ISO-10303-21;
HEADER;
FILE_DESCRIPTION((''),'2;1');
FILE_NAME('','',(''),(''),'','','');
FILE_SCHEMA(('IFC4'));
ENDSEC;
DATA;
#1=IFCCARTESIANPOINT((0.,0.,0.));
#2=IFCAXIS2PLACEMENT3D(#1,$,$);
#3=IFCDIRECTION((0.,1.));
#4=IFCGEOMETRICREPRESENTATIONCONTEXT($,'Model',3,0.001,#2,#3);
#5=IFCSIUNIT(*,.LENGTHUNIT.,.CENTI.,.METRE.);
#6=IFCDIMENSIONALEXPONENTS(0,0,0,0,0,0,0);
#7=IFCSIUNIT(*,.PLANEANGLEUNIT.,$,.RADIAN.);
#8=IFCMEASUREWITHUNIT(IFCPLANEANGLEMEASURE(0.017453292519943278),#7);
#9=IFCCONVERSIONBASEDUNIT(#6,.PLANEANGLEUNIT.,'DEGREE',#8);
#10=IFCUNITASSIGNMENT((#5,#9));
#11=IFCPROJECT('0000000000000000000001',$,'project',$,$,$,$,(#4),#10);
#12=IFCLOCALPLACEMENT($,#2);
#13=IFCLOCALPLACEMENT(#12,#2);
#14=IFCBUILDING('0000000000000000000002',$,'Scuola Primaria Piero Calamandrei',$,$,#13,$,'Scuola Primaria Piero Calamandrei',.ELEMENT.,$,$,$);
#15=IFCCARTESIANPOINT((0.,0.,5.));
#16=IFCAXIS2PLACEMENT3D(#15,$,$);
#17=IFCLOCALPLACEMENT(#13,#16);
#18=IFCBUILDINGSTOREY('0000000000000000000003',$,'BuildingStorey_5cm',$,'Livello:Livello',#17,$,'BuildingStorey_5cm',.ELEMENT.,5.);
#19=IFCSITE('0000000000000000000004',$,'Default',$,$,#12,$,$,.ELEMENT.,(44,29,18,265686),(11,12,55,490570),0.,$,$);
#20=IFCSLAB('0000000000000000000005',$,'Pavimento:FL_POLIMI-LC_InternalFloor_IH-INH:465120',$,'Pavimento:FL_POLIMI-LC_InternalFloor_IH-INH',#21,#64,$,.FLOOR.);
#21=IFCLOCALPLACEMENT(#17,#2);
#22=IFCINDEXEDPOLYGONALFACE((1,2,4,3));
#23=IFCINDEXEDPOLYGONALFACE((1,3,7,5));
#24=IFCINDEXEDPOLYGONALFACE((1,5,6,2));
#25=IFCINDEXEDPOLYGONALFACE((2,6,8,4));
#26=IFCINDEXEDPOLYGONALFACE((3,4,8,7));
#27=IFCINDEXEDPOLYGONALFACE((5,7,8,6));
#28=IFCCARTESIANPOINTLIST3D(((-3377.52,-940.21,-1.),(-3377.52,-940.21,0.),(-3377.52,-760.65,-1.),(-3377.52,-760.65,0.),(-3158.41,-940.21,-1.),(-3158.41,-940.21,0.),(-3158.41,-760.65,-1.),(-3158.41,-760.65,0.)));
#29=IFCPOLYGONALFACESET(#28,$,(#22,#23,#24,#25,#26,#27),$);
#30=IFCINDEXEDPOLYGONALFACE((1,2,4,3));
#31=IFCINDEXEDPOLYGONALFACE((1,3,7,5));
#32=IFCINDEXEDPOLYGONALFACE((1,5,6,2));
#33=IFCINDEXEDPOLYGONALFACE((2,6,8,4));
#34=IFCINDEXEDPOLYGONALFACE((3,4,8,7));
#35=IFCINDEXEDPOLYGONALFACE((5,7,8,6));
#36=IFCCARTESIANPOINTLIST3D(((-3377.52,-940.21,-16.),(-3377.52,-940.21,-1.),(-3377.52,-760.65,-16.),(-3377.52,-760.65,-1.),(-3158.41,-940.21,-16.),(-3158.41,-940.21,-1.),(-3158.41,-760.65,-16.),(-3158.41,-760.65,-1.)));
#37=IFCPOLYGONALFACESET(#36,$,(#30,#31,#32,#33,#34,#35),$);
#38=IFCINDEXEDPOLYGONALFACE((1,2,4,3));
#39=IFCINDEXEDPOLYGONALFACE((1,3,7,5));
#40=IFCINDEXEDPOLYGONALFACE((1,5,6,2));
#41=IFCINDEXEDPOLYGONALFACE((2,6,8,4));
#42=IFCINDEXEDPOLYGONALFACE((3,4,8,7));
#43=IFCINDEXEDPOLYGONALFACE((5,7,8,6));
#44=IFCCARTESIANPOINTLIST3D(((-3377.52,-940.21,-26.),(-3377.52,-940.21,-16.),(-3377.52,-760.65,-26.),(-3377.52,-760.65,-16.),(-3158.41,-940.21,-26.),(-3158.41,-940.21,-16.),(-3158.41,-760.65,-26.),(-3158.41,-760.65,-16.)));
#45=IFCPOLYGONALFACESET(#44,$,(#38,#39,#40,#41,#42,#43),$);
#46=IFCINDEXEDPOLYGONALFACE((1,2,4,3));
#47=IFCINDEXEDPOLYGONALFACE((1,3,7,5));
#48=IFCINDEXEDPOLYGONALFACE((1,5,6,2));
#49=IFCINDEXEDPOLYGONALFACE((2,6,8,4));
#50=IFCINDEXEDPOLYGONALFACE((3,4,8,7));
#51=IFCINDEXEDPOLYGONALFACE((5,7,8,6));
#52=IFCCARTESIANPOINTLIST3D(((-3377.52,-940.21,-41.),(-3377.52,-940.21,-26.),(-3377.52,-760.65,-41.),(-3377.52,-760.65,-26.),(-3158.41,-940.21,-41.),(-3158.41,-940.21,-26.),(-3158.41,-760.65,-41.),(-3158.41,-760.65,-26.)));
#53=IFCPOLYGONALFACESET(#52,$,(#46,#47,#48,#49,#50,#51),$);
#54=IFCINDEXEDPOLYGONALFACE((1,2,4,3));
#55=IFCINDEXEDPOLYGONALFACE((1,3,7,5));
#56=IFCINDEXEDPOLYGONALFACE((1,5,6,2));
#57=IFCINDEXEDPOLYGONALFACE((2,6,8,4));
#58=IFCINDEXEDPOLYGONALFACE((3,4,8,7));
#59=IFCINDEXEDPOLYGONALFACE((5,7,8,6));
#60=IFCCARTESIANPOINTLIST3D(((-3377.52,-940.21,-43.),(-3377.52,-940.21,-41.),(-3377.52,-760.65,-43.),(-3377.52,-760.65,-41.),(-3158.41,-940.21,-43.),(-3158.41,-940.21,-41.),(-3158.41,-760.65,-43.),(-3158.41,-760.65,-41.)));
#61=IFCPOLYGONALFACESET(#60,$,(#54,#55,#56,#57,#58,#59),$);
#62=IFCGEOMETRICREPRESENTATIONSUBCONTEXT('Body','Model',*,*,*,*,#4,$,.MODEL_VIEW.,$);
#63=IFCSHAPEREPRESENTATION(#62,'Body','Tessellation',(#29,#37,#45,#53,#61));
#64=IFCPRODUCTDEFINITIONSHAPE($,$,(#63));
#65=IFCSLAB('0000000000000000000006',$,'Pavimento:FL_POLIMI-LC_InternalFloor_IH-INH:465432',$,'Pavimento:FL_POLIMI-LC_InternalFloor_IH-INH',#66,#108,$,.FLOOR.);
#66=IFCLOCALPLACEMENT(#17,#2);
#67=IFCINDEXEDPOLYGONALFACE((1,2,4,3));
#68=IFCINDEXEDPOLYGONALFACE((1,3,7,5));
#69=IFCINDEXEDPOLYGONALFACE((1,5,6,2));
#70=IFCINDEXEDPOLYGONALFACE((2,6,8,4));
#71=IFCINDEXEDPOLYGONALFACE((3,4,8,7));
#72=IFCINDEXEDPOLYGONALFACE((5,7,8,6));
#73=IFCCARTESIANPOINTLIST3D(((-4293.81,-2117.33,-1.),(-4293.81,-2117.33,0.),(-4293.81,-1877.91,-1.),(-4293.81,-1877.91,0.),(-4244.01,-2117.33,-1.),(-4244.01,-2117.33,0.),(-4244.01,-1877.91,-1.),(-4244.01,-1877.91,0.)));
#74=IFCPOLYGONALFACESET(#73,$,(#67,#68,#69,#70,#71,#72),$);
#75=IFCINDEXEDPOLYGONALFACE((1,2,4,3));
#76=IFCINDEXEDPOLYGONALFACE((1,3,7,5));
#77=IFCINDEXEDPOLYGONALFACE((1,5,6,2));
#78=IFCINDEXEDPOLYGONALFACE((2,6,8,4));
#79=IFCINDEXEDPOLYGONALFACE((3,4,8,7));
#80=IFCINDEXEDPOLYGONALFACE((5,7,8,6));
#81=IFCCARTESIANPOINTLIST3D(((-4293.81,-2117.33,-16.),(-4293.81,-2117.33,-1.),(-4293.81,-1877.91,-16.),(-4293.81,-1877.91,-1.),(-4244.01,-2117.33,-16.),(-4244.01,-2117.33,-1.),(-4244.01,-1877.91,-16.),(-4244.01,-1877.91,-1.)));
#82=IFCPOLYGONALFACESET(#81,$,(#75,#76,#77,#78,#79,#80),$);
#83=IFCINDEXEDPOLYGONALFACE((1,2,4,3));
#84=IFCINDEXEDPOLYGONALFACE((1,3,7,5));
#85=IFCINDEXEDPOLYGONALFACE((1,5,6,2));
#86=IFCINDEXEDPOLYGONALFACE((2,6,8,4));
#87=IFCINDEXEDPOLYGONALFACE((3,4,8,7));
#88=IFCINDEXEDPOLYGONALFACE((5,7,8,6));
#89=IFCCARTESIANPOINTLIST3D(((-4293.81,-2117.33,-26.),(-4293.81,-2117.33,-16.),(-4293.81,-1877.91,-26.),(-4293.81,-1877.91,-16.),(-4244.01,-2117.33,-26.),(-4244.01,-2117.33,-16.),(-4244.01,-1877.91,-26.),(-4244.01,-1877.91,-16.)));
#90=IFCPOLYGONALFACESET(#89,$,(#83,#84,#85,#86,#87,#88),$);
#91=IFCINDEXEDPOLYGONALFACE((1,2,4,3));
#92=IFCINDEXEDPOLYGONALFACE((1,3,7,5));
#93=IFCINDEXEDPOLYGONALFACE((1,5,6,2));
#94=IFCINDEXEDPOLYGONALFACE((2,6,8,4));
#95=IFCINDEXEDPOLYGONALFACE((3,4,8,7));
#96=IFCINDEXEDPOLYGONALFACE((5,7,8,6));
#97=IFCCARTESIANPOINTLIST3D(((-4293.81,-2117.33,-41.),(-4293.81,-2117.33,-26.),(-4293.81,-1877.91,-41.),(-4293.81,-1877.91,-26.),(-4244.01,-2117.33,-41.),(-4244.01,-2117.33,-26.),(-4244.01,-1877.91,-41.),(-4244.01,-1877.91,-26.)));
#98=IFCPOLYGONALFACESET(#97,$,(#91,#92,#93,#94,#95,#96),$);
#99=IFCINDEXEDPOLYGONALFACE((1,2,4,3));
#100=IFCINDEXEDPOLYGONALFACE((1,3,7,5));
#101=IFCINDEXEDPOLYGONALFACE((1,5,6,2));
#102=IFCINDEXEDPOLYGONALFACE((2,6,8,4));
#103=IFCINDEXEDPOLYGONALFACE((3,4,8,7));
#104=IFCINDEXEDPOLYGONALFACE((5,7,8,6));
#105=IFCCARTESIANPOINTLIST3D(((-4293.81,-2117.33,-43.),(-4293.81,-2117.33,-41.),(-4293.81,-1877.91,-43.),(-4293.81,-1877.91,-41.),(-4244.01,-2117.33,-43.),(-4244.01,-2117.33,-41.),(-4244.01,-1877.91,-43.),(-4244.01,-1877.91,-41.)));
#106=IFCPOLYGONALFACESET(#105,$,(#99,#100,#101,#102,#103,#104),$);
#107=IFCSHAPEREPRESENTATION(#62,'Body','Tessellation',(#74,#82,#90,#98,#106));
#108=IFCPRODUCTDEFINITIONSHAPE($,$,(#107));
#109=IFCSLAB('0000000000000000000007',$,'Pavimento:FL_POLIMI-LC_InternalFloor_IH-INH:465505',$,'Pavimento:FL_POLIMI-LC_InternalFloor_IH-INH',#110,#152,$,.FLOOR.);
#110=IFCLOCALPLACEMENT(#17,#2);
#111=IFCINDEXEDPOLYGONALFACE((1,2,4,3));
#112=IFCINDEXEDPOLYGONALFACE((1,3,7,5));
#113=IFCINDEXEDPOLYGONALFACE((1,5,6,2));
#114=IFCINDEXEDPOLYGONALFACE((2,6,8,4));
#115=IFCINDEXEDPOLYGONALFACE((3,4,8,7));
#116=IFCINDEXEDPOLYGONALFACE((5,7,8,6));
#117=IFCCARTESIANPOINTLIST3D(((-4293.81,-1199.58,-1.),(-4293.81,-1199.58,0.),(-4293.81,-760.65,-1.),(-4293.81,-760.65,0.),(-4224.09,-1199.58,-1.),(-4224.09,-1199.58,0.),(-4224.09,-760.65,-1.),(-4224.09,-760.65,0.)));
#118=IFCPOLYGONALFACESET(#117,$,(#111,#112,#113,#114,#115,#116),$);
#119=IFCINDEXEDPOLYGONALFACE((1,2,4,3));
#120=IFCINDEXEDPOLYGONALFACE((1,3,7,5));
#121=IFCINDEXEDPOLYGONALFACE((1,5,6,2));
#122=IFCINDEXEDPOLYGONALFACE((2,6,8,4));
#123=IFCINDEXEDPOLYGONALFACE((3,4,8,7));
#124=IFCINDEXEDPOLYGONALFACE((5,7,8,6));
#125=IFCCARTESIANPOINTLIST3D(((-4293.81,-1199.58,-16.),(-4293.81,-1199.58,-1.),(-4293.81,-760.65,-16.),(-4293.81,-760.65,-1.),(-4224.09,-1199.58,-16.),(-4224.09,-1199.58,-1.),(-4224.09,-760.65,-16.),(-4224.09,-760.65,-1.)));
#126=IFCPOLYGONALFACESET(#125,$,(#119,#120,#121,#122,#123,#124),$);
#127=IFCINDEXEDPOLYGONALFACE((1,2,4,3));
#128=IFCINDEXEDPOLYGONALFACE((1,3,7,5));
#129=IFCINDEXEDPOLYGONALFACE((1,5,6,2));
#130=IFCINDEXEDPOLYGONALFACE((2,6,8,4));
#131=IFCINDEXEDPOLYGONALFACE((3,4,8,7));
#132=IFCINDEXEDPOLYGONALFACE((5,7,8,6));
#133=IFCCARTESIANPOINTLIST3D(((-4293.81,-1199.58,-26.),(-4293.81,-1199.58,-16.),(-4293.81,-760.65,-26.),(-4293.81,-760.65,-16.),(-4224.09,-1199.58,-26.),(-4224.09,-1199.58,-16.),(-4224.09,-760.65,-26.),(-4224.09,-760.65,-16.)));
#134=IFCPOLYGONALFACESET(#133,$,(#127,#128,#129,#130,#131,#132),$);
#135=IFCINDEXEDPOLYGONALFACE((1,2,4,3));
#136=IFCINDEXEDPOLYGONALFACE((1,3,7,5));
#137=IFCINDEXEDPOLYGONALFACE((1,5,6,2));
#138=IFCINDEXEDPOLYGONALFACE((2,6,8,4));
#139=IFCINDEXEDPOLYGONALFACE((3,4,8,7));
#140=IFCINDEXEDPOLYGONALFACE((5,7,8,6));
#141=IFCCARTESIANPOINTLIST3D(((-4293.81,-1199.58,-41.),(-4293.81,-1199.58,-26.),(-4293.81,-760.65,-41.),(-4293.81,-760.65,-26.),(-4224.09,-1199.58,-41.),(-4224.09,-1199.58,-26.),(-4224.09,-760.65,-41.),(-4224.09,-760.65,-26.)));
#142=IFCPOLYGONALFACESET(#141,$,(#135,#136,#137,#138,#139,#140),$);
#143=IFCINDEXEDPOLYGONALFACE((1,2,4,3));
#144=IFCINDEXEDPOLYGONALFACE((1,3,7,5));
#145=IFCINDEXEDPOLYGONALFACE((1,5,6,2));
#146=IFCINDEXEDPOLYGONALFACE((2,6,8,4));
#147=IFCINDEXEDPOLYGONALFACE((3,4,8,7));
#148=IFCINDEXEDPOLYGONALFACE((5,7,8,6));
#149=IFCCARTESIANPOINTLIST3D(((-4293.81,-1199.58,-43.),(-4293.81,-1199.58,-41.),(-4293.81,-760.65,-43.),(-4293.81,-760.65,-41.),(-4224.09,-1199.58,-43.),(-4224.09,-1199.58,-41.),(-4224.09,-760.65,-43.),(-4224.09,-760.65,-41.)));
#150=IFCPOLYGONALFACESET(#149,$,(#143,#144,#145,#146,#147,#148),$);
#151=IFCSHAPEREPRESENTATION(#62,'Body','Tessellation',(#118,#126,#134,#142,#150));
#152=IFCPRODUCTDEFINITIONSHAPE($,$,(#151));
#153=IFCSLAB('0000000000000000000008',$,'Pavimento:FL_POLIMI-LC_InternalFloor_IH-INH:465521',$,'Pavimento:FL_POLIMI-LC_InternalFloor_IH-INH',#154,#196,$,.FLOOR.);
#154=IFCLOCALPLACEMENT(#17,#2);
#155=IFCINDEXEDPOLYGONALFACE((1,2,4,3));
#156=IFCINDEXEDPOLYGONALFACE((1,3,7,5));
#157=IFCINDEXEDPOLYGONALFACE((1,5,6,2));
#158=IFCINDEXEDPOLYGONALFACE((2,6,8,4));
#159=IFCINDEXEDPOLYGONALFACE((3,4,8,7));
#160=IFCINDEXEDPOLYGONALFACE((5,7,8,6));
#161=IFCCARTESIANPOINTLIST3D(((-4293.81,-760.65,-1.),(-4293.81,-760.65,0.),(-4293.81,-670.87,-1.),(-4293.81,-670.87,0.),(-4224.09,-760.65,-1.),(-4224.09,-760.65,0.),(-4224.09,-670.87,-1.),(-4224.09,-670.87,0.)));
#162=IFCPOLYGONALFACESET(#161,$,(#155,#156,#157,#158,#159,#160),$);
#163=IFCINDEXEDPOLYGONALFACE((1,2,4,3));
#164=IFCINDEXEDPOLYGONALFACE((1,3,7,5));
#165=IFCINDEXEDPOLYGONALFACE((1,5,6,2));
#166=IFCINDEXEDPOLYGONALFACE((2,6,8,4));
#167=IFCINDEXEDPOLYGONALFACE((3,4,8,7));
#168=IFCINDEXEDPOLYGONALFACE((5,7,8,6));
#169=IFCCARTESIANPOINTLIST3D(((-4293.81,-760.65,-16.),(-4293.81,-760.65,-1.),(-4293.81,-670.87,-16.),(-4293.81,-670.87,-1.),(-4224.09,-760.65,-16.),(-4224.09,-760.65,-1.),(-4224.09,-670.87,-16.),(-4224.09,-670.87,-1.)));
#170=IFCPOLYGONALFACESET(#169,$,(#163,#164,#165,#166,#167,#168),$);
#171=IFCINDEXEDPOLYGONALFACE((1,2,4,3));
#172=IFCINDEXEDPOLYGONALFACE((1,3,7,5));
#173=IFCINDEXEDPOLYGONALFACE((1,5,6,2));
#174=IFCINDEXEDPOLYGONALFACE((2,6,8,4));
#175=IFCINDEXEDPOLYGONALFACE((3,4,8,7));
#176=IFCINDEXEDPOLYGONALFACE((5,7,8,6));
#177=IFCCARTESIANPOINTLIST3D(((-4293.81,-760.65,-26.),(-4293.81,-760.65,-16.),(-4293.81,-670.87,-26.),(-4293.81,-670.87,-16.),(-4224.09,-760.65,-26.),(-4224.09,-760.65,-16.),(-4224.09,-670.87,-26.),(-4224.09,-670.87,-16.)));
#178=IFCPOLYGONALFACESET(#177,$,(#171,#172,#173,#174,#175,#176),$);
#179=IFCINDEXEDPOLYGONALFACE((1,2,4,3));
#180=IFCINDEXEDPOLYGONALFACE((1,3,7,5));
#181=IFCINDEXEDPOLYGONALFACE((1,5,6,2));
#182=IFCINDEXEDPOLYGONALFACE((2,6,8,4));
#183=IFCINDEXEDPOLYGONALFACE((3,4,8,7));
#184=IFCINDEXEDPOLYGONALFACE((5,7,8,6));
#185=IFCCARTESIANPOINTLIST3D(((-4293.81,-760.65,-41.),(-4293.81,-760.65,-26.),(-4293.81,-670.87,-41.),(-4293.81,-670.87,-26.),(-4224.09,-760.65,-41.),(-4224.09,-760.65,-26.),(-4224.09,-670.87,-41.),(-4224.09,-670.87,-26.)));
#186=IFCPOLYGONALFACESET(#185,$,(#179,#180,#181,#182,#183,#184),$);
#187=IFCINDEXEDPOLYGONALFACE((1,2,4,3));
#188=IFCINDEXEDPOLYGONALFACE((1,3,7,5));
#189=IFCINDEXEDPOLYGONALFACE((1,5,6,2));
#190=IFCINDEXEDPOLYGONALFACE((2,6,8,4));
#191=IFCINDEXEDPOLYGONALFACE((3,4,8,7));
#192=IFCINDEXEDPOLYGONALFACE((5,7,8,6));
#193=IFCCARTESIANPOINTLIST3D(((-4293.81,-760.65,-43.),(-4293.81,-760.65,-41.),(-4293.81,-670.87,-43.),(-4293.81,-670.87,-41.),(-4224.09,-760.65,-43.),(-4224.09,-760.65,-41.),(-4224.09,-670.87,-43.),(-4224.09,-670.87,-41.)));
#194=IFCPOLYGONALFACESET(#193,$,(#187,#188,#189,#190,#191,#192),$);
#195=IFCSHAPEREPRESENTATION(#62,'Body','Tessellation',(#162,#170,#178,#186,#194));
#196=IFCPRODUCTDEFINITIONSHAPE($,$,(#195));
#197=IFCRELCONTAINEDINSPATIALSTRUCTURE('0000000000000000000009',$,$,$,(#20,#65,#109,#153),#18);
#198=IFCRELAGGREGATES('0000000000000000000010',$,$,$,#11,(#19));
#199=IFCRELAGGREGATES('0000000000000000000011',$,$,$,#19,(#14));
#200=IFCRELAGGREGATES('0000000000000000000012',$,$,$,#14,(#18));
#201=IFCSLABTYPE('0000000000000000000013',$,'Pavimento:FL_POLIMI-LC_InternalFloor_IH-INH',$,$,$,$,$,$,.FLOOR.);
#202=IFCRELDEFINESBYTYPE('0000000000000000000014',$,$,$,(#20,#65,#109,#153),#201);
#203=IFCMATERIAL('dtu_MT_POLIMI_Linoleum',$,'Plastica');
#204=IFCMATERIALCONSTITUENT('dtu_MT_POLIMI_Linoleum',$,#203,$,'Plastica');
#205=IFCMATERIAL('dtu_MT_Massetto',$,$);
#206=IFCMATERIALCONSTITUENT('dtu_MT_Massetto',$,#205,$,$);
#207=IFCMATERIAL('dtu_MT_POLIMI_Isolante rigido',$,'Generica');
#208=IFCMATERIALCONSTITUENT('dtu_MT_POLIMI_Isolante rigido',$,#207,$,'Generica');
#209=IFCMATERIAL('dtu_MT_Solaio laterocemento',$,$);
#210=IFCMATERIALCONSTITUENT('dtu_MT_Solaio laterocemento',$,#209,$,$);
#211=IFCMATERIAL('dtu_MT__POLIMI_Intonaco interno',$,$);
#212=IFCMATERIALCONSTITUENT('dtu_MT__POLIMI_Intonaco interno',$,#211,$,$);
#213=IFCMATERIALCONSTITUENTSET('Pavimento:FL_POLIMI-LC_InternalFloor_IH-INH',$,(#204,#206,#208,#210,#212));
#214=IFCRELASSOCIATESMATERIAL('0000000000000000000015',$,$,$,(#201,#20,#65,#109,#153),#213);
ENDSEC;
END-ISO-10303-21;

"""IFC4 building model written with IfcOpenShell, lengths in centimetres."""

from ifc_helpers import new_model, entity, si_unit, converted_unit, direction, frame, origin, place, context, subcontext, project, spatial, indexed_curve, outline, extrude, material, constituent, constituent_set, type_object, element, save


model = new_model("IFC4")

# Units and contexts
model_context = context("Model", 3, precision=0.001, world=origin(), true_north=direction((0.0, 1.0)))
body_context = subcontext(model_context, "Body", "Model", "MODEL_VIEW")
ifc_project = project(units=[si_unit("LENGTHUNIT", "METRE", prefix="CENTI"), converted_unit("PLANEANGLEUNIT", "DEGREE", entity("IfcPlaneAngleMeasure", 0.017453292519943278), si_unit("PLANEANGLEUNIT", "RADIAN"), dimensions=[0, 0, 0, 0, 0, 0, 0])], contexts=[model_context])

# Site, building, storey
site_placement = place(None, origin())
site = spatial("IfcSite", under=ifc_project, at=site_placement, Name="Default", CompositionType="ELEMENT", RefLatitude=(44, 29, 18, 265686), RefLongitude=(11, 12, 55, 490570), RefElevation=0.0)
building_placement = place(site_placement, origin())
building = spatial("IfcBuilding", under=site, at=building_placement, Name="Scuola Primaria Piero Calamandrei", LongName="Scuola Primaria Piero Calamandrei", CompositionType="ELEMENT")
storey_placement = place(building_placement, frame((0.0, 0.0, 5.0)))
storey = spatial("IfcBuildingStorey", under=building, at=storey_placement, Name="BuildingStorey_5cm", ObjectType="Livello:Livello", LongName="BuildingStorey_5cm", CompositionType="ELEMENT", Elevation=5.0)

# Slabs
ifc_material_1 = material(Name="dtu_MT_POLIMI_Linoleum", Category="Plastica")
ifc_constituent_1 = constituent(ifc_material_1, Name="dtu_MT_POLIMI_Linoleum", Category="Plastica")
ifc_material_2 = material(Name="dtu_MT_Massetto")
ifc_constituent_2 = constituent(ifc_material_2, Name="dtu_MT_Massetto")
ifc_material_3 = material(Name="dtu_MT_POLIMI_Isolante rigido", Category="Generica")
ifc_constituent_3 = constituent(ifc_material_3, Name="dtu_MT_POLIMI_Isolante rigido", Category="Generica")
ifc_material_4 = material(Name="dtu_MT_Solaio laterocemento")
ifc_constituent_4 = constituent(ifc_material_4, Name="dtu_MT_Solaio laterocemento")
ifc_material_5 = material(Name="dtu_MT__POLIMI_Intonaco interno")
ifc_constituent_5 = constituent(ifc_material_5, Name="dtu_MT__POLIMI_Intonaco interno")
ifc_constituent_set_1 = constituent_set(constituents=[ifc_constituent_1, ifc_constituent_2, ifc_constituent_3, ifc_constituent_4, ifc_constituent_5], Name="Pavimento:FL_POLIMI-LC_InternalFloor_IH-INH")
slab_type_1 = type_object("IfcSlabType", Name="Pavimento:FL_POLIMI-LC_InternalFloor_IH-INH", PredefinedType="FLOOR", material=ifc_constituent_set_1)
slab_1_placement = place(storey_placement, origin())
element("IfcSlab", 1, at=slab_1_placement, inside=storey, type_object=slab_type_1, material=ifc_constituent_set_1, Name="Pavimento:FL_POLIMI-LC_InternalFloor_IH-INH:465120", ObjectType="Pavimento:FL_POLIMI-LC_InternalFloor_IH-INH", PredefinedType="FLOOR", context=body_context, shape_type="SweptSolid", body=[
    extrude(outline(indexed_curve([(-109.56, -89.78), (109.56, -89.78), (109.56, 89.78), (-109.56, 89.78), (-109.56, -89.78)], self_intersect=False)), frame((-3267.97, -850.43, -1.0), z_axis=(0.0, 0.0, 1.0), x_axis=(-1.0, 0.0, 0.0)), (0.0, 0.0, 1.0), 1.0),
    extrude(outline(indexed_curve([(-109.56, -89.78), (109.56, -89.78), (109.56, 89.78), (-109.56, 89.78), (-109.56, -89.78)], self_intersect=False)), frame((-3267.97, -850.43, -16.0), z_axis=(0.0, 0.0, 1.0), x_axis=(-1.0, 0.0, 0.0)), (0.0, 0.0, 1.0), 15.0),
    extrude(outline(indexed_curve([(-109.56, -89.78), (109.56, -89.78), (109.56, 89.78), (-109.56, 89.78), (-109.56, -89.78)], self_intersect=False)), frame((-3267.97, -850.43, -26.0), z_axis=(0.0, 0.0, 1.0), x_axis=(-1.0, 0.0, 0.0)), (0.0, 0.0, 1.0), 10.0),
    extrude(outline(indexed_curve([(-109.56, -89.78), (109.56, -89.78), (109.56, 89.78), (-109.56, 89.78), (-109.56, -89.78)], self_intersect=False)), frame((-3267.97, -850.43, -41.0), z_axis=(0.0, 0.0, 1.0), x_axis=(-1.0, 0.0, 0.0)), (0.0, 0.0, 1.0), 15.0),
    extrude(outline(indexed_curve([(-109.56, -89.78), (109.56, -89.78), (109.56, 89.78), (-109.56, 89.78), (-109.56, -89.78)], self_intersect=False)), frame((-3267.97, -850.43, -43.0), z_axis=(0.0, 0.0, 1.0), x_axis=(-1.0, 0.0, 0.0)), (0.0, 0.0, 1.0), 2.0),
])
slab_2_placement = place(storey_placement, origin())
element("IfcSlab", 2, at=slab_2_placement, inside=storey, type_object=slab_type_1, material=ifc_constituent_set_1, Name="Pavimento:FL_POLIMI-LC_InternalFloor_IH-INH:465432", ObjectType="Pavimento:FL_POLIMI-LC_InternalFloor_IH-INH", PredefinedType="FLOOR", context=body_context, shape_type="SweptSolid", body=[
    extrude(outline(indexed_curve([(-119.71, -24.9), (119.71, -24.9), (119.71, 24.9), (-119.71, 24.9), (-119.71, -24.9)], self_intersect=False)), frame((-4268.91, -1997.62, -1.0), z_axis=(0.0, 0.0, 1.0), x_axis=(0.0, -1.0, 0.0)), (0.0, 0.0, 1.0), 1.0),
    extrude(outline(indexed_curve([(-119.71, -24.9), (119.71, -24.9), (119.71, 24.9), (-119.71, 24.9), (-119.71, -24.9)], self_intersect=False)), frame((-4268.91, -1997.62, -16.0), z_axis=(0.0, 0.0, 1.0), x_axis=(0.0, -1.0, 0.0)), (0.0, 0.0, 1.0), 15.0),
    extrude(outline(indexed_curve([(-119.71, -24.9), (119.71, -24.9), (119.71, 24.9), (-119.71, 24.9), (-119.71, -24.9)], self_intersect=False)), frame((-4268.91, -1997.62, -26.0), z_axis=(0.0, 0.0, 1.0), x_axis=(0.0, -1.0, 0.0)), (0.0, 0.0, 1.0), 10.0),
    extrude(outline(indexed_curve([(-119.71, -24.9), (119.71, -24.9), (119.71, 24.9), (-119.71, 24.9), (-119.71, -24.9)], self_intersect=False)), frame((-4268.91, -1997.62, -41.0), z_axis=(0.0, 0.0, 1.0), x_axis=(0.0, -1.0, 0.0)), (0.0, 0.0, 1.0), 15.0),
    extrude(outline(indexed_curve([(-119.71, -24.9), (119.71, -24.9), (119.71, 24.9), (-119.71, 24.9), (-119.71, -24.9)], self_intersect=False)), frame((-4268.91, -1997.62, -43.0), z_axis=(0.0, 0.0, 1.0), x_axis=(0.0, -1.0, 0.0)), (0.0, 0.0, 1.0), 2.0),
])
slab_3_placement = place(storey_placement, origin())
element("IfcSlab", 3, at=slab_3_placement, inside=storey, type_object=slab_type_1, material=ifc_constituent_set_1, Name="Pavimento:FL_POLIMI-LC_InternalFloor_IH-INH:465505", ObjectType="Pavimento:FL_POLIMI-LC_InternalFloor_IH-INH", PredefinedType="FLOOR", context=body_context, shape_type="SweptSolid", body=[
    extrude(outline(indexed_curve([(-219.46, -34.86), (219.46, -34.86), (219.46, 34.86), (-219.46, 34.86), (-219.46, -34.86)], self_intersect=False)), frame((-4258.95, -980.11, -1.0), z_axis=(0.0, 0.0, 1.0), x_axis=(0.0, -1.0, 0.0)), (0.0, 0.0, 1.0), 1.0),
    extrude(outline(indexed_curve([(-219.46, -34.86), (219.46, -34.86), (219.46, 34.86), (-219.46, 34.86), (-219.46, -34.86)], self_intersect=False)), frame((-4258.95, -980.11, -16.0), z_axis=(0.0, 0.0, 1.0), x_axis=(0.0, -1.0, 0.0)), (0.0, 0.0, 1.0), 15.0),
    extrude(outline(indexed_curve([(-219.46, -34.86), (219.46, -34.86), (219.46, 34.86), (-219.46, 34.86), (-219.46, -34.86)], self_intersect=False)), frame((-4258.95, -980.11, -26.0), z_axis=(0.0, 0.0, 1.0), x_axis=(0.0, -1.0, 0.0)), (0.0, 0.0, 1.0), 10.0),
    extrude(outline(indexed_curve([(-219.46, -34.86), (219.46, -34.86), (219.46, 34.86), (-219.46, 34.86), (-219.46, -34.86)], self_intersect=False)), frame((-4258.95, -980.11, -41.0), z_axis=(0.0, 0.0, 1.0), x_axis=(0.0, -1.0, 0.0)), (0.0, 0.0, 1.0), 15.0),
    extrude(outline(indexed_curve([(-219.46, -34.86), (219.46, -34.86), (219.46, 34.86), (-219.46, 34.86), (-219.46, -34.86)], self_intersect=False)), frame((-4258.95, -980.11, -43.0), z_axis=(0.0, 0.0, 1.0), x_axis=(0.0, -1.0, 0.0)), (0.0, 0.0, 1.0), 2.0),
])
slab_4_placement = place(storey_placement, origin())
element("IfcSlab", 4, at=slab_4_placement, inside=storey, type_object=slab_type_1, material=ifc_constituent_set_1, Name="Pavimento:FL_POLIMI-LC_InternalFloor_IH-INH:465521", ObjectType="Pavimento:FL_POLIMI-LC_InternalFloor_IH-INH", PredefinedType="FLOOR", context=body_context, shape_type="SweptSolid", body=[
    extrude(outline(indexed_curve([(-44.89, -34.86), (44.89, -34.86), (44.89, 34.86), (-44.89, 34.86), (-44.89, -34.86)], self_intersect=False)), frame((-4258.95, -715.76, -1.0), z_axis=(0.0, 0.0, 1.0), x_axis=(0.0, -1.0, 0.0)), (0.0, 0.0, 1.0), 1.0),
    extrude(outline(indexed_curve([(-44.89, -34.86), (44.89, -34.86), (44.89, 34.86), (-44.89, 34.86), (-44.89, -34.86)], self_intersect=False)), frame((-4258.95, -715.76, -16.0), z_axis=(0.0, 0.0, 1.0), x_axis=(0.0, -1.0, 0.0)), (0.0, 0.0, 1.0), 15.0),
    extrude(outline(indexed_curve([(-44.89, -34.86), (44.89, -34.86), (44.89, 34.86), (-44.89, 34.86), (-44.89, -34.86)], self_intersect=False)), frame((-4258.95, -715.76, -26.0), z_axis=(0.0, 0.0, 1.0), x_axis=(0.0, -1.0, 0.0)), (0.0, 0.0, 1.0), 10.0),
    extrude(outline(indexed_curve([(-44.89, -34.86), (44.89, -34.86), (44.89, 34.86), (-44.89, 34.86), (-44.89, -34.86)], self_intersect=False)), frame((-4258.95, -715.76, -41.0), z_axis=(0.0, 0.0, 1.0), x_axis=(0.0, -1.0, 0.0)), (0.0, 0.0, 1.0), 15.0),
    extrude(outline(indexed_curve([(-44.89, -34.86), (44.89, -34.86), (44.89, 34.86), (-44.89, 34.86), (-44.89, -34.86)], self_intersect=False)), frame((-4258.95, -715.76, -43.0), z_axis=(0.0, 0.0, 1.0), x_axis=(0.0, -1.0, 0.0)), (0.0, 0.0, 1.0), 2.0),
])

save(model, "model.ifc")
